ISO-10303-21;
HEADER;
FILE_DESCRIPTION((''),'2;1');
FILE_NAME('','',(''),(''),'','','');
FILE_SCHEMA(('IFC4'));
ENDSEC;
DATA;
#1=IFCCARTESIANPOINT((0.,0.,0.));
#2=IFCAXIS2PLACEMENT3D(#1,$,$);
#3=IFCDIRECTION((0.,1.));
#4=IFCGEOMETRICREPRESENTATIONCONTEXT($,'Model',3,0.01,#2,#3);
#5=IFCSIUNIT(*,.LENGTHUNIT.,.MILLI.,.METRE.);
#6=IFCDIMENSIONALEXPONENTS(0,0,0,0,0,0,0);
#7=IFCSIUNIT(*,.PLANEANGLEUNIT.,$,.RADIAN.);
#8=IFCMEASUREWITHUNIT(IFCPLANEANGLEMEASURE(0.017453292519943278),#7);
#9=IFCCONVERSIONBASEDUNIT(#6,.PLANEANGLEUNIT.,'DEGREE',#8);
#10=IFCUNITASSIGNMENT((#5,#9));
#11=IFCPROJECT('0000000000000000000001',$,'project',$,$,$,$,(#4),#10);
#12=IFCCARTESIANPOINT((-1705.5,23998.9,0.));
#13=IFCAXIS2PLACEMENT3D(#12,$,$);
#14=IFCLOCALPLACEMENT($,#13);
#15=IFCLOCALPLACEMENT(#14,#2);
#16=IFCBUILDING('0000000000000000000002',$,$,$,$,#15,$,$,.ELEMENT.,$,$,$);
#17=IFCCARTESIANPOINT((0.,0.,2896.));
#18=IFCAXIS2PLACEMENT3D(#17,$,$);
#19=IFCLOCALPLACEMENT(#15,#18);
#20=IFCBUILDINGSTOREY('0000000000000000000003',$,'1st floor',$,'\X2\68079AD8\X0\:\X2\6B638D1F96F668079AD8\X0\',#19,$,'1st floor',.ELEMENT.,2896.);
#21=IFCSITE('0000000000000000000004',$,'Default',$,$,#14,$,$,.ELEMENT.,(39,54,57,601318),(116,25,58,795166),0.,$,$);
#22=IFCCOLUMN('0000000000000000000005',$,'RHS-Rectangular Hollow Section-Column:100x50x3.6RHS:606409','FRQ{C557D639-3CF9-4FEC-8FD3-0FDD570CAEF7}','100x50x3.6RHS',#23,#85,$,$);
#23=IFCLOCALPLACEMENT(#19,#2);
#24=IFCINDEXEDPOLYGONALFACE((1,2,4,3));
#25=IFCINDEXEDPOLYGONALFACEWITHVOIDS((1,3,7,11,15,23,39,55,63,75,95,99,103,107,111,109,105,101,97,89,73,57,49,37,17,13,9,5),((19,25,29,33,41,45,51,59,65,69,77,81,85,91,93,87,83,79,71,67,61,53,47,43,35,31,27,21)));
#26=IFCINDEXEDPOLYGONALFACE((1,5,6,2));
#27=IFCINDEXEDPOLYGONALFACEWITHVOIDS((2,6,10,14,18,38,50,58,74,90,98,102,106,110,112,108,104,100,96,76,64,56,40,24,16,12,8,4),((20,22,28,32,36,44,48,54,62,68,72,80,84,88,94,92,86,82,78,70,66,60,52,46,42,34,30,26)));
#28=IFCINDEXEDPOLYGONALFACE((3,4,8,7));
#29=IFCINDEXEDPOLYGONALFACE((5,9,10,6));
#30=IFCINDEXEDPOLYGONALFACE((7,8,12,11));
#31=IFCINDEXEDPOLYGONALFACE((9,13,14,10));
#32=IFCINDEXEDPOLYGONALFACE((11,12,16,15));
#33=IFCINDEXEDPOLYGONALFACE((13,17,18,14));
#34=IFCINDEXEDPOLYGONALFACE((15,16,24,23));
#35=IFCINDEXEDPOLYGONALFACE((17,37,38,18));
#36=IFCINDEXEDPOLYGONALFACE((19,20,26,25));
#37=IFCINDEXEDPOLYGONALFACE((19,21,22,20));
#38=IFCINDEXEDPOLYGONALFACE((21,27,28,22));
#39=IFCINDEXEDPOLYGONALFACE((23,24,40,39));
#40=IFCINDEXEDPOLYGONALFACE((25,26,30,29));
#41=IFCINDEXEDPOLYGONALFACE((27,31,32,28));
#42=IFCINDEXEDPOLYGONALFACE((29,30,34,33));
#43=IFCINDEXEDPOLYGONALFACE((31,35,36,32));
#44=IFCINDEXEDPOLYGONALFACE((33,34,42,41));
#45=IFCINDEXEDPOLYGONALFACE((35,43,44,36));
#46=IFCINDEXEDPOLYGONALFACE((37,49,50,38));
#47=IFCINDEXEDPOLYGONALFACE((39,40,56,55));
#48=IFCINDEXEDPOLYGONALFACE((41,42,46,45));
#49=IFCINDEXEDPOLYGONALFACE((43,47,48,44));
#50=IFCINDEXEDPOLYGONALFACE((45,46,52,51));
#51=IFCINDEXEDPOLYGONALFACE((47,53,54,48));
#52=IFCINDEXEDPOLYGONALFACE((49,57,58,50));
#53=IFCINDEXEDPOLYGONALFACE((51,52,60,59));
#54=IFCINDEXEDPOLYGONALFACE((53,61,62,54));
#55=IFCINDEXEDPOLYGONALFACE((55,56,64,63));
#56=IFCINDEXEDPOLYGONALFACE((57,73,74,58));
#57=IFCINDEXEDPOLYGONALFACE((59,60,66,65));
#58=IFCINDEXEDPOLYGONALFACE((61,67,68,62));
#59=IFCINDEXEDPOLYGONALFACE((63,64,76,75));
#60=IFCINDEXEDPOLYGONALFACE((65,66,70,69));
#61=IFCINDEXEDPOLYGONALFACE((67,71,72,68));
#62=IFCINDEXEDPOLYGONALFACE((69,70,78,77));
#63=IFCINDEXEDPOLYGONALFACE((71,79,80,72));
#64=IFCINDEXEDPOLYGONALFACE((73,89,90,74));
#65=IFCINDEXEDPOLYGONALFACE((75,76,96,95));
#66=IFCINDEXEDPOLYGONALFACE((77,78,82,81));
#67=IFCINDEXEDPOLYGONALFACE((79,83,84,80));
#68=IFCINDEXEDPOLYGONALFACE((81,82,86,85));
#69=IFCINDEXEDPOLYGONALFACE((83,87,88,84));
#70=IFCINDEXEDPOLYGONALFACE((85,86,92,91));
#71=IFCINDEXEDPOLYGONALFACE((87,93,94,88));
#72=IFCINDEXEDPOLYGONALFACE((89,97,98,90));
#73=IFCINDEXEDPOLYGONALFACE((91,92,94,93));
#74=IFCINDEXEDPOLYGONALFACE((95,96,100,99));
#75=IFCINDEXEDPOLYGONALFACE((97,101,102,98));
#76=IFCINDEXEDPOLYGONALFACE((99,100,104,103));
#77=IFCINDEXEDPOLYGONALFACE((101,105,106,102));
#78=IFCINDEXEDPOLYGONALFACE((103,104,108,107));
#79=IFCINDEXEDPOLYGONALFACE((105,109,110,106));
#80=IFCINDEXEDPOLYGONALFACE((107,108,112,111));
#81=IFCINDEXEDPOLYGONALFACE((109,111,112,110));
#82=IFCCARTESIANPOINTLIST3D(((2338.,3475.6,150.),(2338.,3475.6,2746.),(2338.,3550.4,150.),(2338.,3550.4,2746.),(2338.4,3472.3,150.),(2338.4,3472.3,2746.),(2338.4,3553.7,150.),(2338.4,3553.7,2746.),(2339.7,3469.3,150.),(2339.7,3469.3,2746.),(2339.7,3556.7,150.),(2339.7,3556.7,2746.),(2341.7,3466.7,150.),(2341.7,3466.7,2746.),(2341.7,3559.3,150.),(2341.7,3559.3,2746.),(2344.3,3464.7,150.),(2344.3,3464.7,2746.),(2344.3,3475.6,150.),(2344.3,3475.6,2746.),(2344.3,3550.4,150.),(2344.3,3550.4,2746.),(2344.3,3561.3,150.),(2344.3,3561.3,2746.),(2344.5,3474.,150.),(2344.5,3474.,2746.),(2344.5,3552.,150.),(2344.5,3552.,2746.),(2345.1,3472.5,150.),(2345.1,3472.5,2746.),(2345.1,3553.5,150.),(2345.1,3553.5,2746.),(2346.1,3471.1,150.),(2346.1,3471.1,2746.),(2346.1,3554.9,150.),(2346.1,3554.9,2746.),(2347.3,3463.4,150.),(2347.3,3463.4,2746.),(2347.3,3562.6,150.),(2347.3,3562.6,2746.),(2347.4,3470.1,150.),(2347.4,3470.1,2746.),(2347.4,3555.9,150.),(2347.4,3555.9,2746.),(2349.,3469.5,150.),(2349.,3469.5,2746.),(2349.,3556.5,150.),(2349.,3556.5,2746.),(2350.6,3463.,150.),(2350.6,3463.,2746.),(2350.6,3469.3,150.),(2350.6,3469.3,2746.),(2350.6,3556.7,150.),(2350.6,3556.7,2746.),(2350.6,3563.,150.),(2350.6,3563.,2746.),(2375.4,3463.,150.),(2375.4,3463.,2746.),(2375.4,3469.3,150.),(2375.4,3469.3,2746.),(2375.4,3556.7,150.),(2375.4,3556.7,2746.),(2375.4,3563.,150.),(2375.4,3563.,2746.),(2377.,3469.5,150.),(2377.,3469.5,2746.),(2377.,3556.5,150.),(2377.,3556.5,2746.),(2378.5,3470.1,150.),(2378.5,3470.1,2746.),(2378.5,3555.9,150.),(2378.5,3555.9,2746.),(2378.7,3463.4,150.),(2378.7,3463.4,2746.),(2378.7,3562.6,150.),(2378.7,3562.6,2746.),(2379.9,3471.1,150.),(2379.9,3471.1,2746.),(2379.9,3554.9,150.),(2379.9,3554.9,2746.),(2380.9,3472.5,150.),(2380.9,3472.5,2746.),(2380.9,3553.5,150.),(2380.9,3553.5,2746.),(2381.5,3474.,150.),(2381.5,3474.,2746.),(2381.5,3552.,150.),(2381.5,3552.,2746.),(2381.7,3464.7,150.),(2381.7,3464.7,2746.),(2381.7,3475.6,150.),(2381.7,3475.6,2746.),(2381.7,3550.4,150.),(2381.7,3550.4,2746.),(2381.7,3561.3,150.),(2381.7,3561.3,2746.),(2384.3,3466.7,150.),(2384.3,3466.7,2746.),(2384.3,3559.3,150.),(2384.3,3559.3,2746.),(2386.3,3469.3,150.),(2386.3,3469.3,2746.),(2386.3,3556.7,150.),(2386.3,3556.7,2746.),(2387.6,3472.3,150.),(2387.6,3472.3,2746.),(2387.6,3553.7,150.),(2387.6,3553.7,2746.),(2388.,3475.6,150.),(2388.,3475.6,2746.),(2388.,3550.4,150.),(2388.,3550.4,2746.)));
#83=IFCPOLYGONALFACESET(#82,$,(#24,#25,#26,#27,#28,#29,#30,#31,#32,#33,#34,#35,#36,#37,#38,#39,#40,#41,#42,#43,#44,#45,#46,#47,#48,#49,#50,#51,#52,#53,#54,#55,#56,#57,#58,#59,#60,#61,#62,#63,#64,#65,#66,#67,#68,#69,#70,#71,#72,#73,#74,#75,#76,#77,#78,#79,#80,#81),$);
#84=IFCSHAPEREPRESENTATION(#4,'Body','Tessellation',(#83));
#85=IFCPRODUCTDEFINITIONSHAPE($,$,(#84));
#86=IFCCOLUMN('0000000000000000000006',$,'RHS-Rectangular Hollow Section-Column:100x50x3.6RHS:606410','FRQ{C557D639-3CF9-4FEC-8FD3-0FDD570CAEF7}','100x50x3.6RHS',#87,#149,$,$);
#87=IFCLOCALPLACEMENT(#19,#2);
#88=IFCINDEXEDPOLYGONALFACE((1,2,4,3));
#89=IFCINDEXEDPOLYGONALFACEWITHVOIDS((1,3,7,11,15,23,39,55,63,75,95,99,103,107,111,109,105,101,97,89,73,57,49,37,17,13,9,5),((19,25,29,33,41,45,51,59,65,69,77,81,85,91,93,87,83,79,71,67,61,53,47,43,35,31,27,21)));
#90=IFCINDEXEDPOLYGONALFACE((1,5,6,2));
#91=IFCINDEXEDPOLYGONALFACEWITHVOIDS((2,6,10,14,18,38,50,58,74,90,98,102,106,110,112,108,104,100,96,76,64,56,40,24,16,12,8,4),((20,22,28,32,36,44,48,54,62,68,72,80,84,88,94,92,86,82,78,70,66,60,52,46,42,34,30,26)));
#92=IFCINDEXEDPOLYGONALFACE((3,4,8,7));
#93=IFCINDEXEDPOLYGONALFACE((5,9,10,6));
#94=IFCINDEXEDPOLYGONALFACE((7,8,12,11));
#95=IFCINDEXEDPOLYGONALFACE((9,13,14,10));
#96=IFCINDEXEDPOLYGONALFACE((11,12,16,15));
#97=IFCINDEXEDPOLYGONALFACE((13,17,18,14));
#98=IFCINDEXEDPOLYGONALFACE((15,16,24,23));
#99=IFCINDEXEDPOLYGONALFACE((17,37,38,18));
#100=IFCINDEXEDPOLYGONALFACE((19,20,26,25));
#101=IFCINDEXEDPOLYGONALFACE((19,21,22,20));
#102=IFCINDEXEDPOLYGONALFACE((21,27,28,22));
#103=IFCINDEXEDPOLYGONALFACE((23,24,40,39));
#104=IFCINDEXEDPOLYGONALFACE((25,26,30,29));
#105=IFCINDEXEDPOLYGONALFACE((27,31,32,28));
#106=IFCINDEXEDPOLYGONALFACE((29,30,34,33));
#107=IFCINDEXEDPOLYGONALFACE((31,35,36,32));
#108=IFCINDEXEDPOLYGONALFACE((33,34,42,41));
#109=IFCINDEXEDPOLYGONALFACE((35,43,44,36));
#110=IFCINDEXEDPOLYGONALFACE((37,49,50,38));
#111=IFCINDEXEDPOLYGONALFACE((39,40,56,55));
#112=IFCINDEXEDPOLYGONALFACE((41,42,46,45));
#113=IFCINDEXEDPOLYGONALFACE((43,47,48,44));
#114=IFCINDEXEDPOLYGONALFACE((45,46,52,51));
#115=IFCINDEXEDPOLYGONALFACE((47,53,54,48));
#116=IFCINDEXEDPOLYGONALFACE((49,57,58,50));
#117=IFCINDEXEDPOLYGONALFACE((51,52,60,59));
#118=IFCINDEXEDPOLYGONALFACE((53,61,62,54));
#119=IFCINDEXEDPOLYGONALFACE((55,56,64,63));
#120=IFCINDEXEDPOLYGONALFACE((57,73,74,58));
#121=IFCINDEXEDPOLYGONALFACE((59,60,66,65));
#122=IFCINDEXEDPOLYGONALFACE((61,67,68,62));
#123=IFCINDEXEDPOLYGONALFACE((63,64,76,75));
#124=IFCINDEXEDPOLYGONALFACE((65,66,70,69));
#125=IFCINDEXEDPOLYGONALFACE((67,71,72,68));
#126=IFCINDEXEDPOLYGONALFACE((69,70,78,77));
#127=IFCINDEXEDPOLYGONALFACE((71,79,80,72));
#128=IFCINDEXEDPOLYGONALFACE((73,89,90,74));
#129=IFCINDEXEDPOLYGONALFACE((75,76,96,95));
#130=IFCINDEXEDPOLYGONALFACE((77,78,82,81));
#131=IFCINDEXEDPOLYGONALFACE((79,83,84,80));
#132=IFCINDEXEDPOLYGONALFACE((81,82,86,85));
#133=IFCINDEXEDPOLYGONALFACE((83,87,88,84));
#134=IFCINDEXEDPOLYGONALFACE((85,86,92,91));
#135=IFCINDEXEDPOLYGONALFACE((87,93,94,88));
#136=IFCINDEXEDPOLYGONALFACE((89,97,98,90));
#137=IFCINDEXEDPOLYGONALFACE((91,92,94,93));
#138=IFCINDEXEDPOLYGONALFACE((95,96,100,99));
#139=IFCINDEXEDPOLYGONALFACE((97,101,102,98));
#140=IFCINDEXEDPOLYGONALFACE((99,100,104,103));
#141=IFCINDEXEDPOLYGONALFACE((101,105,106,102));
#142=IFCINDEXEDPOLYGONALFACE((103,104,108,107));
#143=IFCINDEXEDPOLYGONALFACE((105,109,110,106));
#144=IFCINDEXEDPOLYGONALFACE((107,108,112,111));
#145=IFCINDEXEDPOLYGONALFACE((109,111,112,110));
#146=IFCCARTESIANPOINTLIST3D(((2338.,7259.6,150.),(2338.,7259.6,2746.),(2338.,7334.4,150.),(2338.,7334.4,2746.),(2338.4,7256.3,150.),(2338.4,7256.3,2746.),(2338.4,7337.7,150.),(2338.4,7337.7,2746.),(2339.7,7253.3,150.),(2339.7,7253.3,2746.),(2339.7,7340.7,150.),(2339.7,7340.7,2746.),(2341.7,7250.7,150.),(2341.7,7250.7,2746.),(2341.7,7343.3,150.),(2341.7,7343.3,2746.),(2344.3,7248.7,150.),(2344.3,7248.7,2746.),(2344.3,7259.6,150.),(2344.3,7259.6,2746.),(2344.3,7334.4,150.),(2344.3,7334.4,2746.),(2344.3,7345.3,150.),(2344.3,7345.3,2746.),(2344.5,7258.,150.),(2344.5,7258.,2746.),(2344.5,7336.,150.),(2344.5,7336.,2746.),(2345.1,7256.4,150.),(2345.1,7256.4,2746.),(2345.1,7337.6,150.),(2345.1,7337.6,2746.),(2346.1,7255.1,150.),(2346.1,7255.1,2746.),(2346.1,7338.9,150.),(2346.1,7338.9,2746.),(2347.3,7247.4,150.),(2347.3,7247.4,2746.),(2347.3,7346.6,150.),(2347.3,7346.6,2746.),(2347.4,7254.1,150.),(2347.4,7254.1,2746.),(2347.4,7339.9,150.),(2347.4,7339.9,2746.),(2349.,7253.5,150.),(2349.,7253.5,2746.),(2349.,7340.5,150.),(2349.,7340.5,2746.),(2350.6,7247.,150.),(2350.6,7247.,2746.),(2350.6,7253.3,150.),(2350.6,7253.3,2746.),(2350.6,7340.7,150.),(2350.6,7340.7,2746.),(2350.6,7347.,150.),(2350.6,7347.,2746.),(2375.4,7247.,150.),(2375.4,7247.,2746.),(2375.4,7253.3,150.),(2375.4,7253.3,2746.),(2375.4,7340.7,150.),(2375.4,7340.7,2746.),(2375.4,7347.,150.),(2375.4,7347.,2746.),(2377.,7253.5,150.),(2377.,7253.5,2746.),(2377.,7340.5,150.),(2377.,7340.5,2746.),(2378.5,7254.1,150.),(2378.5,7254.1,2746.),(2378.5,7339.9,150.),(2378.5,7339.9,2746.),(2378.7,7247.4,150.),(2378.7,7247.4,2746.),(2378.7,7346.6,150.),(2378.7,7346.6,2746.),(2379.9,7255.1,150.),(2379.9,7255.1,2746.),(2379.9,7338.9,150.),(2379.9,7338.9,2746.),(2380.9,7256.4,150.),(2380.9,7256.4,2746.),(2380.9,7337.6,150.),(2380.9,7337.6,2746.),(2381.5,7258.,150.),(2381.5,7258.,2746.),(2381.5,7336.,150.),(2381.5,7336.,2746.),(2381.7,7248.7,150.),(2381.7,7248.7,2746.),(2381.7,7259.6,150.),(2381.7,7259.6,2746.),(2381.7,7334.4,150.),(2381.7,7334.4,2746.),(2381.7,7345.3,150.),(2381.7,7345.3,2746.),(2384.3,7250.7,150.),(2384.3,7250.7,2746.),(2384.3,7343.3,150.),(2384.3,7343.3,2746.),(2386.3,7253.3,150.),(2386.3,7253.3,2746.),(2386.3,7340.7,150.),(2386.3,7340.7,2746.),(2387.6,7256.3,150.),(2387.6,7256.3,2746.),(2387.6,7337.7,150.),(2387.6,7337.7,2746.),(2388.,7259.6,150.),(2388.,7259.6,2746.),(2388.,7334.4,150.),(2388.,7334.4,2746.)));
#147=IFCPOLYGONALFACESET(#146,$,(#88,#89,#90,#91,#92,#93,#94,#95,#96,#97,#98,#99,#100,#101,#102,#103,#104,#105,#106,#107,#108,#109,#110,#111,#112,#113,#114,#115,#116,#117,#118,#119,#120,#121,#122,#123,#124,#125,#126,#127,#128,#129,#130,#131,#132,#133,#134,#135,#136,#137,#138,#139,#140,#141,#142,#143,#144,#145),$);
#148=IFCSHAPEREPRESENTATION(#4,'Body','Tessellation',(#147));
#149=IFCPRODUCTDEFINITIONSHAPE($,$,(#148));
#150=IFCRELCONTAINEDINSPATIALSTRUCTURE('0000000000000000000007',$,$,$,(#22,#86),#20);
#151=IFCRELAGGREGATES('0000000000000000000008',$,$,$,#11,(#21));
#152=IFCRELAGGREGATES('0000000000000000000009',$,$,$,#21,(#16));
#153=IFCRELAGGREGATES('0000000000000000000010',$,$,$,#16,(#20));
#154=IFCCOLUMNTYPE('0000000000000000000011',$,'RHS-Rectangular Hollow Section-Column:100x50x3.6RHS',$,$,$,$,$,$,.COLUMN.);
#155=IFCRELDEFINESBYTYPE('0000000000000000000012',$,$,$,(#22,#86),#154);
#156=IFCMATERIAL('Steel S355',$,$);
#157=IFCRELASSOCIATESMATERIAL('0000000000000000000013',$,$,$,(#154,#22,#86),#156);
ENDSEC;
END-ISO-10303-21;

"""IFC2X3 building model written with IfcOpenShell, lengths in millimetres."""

from ifc_helpers import new_model, entity, si_unit, converted_unit, direction, frame, origin, origin_2d, place, context, project, spatial, hollow_rectangle, extrude, clip, halfspace, material, type_object, element, save


model = new_model("IFC2X3")

# Units and contexts
model_context = context("Model", 3, precision=0.01, world=origin(), true_north=direction((0.0, 1.0)))
ifc_project = project(units=[si_unit("LENGTHUNIT", "METRE", prefix="MILLI"), converted_unit("PLANEANGLEUNIT", "DEGREE", entity("IfcPlaneAngleMeasure", 0.017453292519943278), si_unit("PLANEANGLEUNIT", "RADIAN"), dimensions=[0, 0, 0, 0, 0, 0, 0])], contexts=[model_context])

# Site, building, storey
site_placement = place(None, frame((-1705.5, 23998.9, 0.0)))
site = spatial("IfcSite", under=ifc_project, at=site_placement, Name="Default", CompositionType="ELEMENT", RefLatitude=(39, 54, 57, 601318), RefLongitude=(116, 25, 58, 795166), RefElevation=0.0)
building_placement = place(site_placement, origin())
building = spatial("IfcBuilding", under=site, at=building_placement, CompositionType="ELEMENT")
storey_placement = place(building_placement, frame((0.0, 0.0, 2896.0)))
storey = spatial("IfcBuildingStorey", under=building, at=storey_placement, Name="1st floor", ObjectType="标高:正负零标高", LongName="1st floor", CompositionType="ELEMENT", Elevation=2896.0)

# Shared definitions
ifc_material_1 = material(Name="Steel S355")

# Columns
column_type_1 = type_object("IfcColumnType", Name="RHS-Rectangular Hollow Section-Column:100x50x3.6RHS", PredefinedType="COLUMN", material=ifc_material_1)
column_1_placement = place(storey_placement, frame((2363.0, 3513.0, 2746.0), z_axis=(0.0, 0.0, 1.0), x_axis=(-1.0, 0.0, 0.0)))
element("IfcColumn", 1, at=column_1_placement, inside=storey, type_object=column_type_1, material=ifc_material_1, Name="RHS-Rectangular Hollow Section-Column:100x50x3.6RHS:606409", Description="FRQ{C557D639-3CF9-4FEC-8FD3-0FDD570CAEF7}", ObjectType="100x50x3.6RHS", context=model_context, shape_type="Clipping", body=[
    clip(extrude(hollow_rectangle(XDim=50.0, YDim=100.0, WallThickness=6.3, InnerFilletRadius=6.3, OuterFilletRadius=12.6, at=origin_2d()), origin(), (0.0, 0.0, -1.0), 2651.9), halfspace(frame((2363.0, 3513.0, -2596.0), z_axis=(0.0, 0.0, 1.0), x_axis=(-1.0, 0.0, 0.0)), True)),
])
column_2_placement = place(storey_placement, frame((2363.0, 7297.0, 2746.0), z_axis=(0.0, 0.0, 1.0), x_axis=(-1.0, 0.0, 0.0)))
element("IfcColumn", 2, at=column_2_placement, inside=storey, type_object=column_type_1, material=ifc_material_1, Name="RHS-Rectangular Hollow Section-Column:100x50x3.6RHS:606410", Description="FRQ{C557D639-3CF9-4FEC-8FD3-0FDD570CAEF7}", ObjectType="100x50x3.6RHS", context=model_context, shape_type="Clipping", body=[
    clip(extrude(hollow_rectangle(XDim=50.0, YDim=100.0, WallThickness=6.3, InnerFilletRadius=6.3, OuterFilletRadius=12.6, at=origin_2d()), origin(), (0.0, 0.0, -1.0), 2651.9), halfspace(frame((2363.0, 7297.0, -2596.0), z_axis=(0.0, 0.0, 1.0), x_axis=(-1.0, 0.0, 0.0)), True)),
])

save(model, "model.ifc")
